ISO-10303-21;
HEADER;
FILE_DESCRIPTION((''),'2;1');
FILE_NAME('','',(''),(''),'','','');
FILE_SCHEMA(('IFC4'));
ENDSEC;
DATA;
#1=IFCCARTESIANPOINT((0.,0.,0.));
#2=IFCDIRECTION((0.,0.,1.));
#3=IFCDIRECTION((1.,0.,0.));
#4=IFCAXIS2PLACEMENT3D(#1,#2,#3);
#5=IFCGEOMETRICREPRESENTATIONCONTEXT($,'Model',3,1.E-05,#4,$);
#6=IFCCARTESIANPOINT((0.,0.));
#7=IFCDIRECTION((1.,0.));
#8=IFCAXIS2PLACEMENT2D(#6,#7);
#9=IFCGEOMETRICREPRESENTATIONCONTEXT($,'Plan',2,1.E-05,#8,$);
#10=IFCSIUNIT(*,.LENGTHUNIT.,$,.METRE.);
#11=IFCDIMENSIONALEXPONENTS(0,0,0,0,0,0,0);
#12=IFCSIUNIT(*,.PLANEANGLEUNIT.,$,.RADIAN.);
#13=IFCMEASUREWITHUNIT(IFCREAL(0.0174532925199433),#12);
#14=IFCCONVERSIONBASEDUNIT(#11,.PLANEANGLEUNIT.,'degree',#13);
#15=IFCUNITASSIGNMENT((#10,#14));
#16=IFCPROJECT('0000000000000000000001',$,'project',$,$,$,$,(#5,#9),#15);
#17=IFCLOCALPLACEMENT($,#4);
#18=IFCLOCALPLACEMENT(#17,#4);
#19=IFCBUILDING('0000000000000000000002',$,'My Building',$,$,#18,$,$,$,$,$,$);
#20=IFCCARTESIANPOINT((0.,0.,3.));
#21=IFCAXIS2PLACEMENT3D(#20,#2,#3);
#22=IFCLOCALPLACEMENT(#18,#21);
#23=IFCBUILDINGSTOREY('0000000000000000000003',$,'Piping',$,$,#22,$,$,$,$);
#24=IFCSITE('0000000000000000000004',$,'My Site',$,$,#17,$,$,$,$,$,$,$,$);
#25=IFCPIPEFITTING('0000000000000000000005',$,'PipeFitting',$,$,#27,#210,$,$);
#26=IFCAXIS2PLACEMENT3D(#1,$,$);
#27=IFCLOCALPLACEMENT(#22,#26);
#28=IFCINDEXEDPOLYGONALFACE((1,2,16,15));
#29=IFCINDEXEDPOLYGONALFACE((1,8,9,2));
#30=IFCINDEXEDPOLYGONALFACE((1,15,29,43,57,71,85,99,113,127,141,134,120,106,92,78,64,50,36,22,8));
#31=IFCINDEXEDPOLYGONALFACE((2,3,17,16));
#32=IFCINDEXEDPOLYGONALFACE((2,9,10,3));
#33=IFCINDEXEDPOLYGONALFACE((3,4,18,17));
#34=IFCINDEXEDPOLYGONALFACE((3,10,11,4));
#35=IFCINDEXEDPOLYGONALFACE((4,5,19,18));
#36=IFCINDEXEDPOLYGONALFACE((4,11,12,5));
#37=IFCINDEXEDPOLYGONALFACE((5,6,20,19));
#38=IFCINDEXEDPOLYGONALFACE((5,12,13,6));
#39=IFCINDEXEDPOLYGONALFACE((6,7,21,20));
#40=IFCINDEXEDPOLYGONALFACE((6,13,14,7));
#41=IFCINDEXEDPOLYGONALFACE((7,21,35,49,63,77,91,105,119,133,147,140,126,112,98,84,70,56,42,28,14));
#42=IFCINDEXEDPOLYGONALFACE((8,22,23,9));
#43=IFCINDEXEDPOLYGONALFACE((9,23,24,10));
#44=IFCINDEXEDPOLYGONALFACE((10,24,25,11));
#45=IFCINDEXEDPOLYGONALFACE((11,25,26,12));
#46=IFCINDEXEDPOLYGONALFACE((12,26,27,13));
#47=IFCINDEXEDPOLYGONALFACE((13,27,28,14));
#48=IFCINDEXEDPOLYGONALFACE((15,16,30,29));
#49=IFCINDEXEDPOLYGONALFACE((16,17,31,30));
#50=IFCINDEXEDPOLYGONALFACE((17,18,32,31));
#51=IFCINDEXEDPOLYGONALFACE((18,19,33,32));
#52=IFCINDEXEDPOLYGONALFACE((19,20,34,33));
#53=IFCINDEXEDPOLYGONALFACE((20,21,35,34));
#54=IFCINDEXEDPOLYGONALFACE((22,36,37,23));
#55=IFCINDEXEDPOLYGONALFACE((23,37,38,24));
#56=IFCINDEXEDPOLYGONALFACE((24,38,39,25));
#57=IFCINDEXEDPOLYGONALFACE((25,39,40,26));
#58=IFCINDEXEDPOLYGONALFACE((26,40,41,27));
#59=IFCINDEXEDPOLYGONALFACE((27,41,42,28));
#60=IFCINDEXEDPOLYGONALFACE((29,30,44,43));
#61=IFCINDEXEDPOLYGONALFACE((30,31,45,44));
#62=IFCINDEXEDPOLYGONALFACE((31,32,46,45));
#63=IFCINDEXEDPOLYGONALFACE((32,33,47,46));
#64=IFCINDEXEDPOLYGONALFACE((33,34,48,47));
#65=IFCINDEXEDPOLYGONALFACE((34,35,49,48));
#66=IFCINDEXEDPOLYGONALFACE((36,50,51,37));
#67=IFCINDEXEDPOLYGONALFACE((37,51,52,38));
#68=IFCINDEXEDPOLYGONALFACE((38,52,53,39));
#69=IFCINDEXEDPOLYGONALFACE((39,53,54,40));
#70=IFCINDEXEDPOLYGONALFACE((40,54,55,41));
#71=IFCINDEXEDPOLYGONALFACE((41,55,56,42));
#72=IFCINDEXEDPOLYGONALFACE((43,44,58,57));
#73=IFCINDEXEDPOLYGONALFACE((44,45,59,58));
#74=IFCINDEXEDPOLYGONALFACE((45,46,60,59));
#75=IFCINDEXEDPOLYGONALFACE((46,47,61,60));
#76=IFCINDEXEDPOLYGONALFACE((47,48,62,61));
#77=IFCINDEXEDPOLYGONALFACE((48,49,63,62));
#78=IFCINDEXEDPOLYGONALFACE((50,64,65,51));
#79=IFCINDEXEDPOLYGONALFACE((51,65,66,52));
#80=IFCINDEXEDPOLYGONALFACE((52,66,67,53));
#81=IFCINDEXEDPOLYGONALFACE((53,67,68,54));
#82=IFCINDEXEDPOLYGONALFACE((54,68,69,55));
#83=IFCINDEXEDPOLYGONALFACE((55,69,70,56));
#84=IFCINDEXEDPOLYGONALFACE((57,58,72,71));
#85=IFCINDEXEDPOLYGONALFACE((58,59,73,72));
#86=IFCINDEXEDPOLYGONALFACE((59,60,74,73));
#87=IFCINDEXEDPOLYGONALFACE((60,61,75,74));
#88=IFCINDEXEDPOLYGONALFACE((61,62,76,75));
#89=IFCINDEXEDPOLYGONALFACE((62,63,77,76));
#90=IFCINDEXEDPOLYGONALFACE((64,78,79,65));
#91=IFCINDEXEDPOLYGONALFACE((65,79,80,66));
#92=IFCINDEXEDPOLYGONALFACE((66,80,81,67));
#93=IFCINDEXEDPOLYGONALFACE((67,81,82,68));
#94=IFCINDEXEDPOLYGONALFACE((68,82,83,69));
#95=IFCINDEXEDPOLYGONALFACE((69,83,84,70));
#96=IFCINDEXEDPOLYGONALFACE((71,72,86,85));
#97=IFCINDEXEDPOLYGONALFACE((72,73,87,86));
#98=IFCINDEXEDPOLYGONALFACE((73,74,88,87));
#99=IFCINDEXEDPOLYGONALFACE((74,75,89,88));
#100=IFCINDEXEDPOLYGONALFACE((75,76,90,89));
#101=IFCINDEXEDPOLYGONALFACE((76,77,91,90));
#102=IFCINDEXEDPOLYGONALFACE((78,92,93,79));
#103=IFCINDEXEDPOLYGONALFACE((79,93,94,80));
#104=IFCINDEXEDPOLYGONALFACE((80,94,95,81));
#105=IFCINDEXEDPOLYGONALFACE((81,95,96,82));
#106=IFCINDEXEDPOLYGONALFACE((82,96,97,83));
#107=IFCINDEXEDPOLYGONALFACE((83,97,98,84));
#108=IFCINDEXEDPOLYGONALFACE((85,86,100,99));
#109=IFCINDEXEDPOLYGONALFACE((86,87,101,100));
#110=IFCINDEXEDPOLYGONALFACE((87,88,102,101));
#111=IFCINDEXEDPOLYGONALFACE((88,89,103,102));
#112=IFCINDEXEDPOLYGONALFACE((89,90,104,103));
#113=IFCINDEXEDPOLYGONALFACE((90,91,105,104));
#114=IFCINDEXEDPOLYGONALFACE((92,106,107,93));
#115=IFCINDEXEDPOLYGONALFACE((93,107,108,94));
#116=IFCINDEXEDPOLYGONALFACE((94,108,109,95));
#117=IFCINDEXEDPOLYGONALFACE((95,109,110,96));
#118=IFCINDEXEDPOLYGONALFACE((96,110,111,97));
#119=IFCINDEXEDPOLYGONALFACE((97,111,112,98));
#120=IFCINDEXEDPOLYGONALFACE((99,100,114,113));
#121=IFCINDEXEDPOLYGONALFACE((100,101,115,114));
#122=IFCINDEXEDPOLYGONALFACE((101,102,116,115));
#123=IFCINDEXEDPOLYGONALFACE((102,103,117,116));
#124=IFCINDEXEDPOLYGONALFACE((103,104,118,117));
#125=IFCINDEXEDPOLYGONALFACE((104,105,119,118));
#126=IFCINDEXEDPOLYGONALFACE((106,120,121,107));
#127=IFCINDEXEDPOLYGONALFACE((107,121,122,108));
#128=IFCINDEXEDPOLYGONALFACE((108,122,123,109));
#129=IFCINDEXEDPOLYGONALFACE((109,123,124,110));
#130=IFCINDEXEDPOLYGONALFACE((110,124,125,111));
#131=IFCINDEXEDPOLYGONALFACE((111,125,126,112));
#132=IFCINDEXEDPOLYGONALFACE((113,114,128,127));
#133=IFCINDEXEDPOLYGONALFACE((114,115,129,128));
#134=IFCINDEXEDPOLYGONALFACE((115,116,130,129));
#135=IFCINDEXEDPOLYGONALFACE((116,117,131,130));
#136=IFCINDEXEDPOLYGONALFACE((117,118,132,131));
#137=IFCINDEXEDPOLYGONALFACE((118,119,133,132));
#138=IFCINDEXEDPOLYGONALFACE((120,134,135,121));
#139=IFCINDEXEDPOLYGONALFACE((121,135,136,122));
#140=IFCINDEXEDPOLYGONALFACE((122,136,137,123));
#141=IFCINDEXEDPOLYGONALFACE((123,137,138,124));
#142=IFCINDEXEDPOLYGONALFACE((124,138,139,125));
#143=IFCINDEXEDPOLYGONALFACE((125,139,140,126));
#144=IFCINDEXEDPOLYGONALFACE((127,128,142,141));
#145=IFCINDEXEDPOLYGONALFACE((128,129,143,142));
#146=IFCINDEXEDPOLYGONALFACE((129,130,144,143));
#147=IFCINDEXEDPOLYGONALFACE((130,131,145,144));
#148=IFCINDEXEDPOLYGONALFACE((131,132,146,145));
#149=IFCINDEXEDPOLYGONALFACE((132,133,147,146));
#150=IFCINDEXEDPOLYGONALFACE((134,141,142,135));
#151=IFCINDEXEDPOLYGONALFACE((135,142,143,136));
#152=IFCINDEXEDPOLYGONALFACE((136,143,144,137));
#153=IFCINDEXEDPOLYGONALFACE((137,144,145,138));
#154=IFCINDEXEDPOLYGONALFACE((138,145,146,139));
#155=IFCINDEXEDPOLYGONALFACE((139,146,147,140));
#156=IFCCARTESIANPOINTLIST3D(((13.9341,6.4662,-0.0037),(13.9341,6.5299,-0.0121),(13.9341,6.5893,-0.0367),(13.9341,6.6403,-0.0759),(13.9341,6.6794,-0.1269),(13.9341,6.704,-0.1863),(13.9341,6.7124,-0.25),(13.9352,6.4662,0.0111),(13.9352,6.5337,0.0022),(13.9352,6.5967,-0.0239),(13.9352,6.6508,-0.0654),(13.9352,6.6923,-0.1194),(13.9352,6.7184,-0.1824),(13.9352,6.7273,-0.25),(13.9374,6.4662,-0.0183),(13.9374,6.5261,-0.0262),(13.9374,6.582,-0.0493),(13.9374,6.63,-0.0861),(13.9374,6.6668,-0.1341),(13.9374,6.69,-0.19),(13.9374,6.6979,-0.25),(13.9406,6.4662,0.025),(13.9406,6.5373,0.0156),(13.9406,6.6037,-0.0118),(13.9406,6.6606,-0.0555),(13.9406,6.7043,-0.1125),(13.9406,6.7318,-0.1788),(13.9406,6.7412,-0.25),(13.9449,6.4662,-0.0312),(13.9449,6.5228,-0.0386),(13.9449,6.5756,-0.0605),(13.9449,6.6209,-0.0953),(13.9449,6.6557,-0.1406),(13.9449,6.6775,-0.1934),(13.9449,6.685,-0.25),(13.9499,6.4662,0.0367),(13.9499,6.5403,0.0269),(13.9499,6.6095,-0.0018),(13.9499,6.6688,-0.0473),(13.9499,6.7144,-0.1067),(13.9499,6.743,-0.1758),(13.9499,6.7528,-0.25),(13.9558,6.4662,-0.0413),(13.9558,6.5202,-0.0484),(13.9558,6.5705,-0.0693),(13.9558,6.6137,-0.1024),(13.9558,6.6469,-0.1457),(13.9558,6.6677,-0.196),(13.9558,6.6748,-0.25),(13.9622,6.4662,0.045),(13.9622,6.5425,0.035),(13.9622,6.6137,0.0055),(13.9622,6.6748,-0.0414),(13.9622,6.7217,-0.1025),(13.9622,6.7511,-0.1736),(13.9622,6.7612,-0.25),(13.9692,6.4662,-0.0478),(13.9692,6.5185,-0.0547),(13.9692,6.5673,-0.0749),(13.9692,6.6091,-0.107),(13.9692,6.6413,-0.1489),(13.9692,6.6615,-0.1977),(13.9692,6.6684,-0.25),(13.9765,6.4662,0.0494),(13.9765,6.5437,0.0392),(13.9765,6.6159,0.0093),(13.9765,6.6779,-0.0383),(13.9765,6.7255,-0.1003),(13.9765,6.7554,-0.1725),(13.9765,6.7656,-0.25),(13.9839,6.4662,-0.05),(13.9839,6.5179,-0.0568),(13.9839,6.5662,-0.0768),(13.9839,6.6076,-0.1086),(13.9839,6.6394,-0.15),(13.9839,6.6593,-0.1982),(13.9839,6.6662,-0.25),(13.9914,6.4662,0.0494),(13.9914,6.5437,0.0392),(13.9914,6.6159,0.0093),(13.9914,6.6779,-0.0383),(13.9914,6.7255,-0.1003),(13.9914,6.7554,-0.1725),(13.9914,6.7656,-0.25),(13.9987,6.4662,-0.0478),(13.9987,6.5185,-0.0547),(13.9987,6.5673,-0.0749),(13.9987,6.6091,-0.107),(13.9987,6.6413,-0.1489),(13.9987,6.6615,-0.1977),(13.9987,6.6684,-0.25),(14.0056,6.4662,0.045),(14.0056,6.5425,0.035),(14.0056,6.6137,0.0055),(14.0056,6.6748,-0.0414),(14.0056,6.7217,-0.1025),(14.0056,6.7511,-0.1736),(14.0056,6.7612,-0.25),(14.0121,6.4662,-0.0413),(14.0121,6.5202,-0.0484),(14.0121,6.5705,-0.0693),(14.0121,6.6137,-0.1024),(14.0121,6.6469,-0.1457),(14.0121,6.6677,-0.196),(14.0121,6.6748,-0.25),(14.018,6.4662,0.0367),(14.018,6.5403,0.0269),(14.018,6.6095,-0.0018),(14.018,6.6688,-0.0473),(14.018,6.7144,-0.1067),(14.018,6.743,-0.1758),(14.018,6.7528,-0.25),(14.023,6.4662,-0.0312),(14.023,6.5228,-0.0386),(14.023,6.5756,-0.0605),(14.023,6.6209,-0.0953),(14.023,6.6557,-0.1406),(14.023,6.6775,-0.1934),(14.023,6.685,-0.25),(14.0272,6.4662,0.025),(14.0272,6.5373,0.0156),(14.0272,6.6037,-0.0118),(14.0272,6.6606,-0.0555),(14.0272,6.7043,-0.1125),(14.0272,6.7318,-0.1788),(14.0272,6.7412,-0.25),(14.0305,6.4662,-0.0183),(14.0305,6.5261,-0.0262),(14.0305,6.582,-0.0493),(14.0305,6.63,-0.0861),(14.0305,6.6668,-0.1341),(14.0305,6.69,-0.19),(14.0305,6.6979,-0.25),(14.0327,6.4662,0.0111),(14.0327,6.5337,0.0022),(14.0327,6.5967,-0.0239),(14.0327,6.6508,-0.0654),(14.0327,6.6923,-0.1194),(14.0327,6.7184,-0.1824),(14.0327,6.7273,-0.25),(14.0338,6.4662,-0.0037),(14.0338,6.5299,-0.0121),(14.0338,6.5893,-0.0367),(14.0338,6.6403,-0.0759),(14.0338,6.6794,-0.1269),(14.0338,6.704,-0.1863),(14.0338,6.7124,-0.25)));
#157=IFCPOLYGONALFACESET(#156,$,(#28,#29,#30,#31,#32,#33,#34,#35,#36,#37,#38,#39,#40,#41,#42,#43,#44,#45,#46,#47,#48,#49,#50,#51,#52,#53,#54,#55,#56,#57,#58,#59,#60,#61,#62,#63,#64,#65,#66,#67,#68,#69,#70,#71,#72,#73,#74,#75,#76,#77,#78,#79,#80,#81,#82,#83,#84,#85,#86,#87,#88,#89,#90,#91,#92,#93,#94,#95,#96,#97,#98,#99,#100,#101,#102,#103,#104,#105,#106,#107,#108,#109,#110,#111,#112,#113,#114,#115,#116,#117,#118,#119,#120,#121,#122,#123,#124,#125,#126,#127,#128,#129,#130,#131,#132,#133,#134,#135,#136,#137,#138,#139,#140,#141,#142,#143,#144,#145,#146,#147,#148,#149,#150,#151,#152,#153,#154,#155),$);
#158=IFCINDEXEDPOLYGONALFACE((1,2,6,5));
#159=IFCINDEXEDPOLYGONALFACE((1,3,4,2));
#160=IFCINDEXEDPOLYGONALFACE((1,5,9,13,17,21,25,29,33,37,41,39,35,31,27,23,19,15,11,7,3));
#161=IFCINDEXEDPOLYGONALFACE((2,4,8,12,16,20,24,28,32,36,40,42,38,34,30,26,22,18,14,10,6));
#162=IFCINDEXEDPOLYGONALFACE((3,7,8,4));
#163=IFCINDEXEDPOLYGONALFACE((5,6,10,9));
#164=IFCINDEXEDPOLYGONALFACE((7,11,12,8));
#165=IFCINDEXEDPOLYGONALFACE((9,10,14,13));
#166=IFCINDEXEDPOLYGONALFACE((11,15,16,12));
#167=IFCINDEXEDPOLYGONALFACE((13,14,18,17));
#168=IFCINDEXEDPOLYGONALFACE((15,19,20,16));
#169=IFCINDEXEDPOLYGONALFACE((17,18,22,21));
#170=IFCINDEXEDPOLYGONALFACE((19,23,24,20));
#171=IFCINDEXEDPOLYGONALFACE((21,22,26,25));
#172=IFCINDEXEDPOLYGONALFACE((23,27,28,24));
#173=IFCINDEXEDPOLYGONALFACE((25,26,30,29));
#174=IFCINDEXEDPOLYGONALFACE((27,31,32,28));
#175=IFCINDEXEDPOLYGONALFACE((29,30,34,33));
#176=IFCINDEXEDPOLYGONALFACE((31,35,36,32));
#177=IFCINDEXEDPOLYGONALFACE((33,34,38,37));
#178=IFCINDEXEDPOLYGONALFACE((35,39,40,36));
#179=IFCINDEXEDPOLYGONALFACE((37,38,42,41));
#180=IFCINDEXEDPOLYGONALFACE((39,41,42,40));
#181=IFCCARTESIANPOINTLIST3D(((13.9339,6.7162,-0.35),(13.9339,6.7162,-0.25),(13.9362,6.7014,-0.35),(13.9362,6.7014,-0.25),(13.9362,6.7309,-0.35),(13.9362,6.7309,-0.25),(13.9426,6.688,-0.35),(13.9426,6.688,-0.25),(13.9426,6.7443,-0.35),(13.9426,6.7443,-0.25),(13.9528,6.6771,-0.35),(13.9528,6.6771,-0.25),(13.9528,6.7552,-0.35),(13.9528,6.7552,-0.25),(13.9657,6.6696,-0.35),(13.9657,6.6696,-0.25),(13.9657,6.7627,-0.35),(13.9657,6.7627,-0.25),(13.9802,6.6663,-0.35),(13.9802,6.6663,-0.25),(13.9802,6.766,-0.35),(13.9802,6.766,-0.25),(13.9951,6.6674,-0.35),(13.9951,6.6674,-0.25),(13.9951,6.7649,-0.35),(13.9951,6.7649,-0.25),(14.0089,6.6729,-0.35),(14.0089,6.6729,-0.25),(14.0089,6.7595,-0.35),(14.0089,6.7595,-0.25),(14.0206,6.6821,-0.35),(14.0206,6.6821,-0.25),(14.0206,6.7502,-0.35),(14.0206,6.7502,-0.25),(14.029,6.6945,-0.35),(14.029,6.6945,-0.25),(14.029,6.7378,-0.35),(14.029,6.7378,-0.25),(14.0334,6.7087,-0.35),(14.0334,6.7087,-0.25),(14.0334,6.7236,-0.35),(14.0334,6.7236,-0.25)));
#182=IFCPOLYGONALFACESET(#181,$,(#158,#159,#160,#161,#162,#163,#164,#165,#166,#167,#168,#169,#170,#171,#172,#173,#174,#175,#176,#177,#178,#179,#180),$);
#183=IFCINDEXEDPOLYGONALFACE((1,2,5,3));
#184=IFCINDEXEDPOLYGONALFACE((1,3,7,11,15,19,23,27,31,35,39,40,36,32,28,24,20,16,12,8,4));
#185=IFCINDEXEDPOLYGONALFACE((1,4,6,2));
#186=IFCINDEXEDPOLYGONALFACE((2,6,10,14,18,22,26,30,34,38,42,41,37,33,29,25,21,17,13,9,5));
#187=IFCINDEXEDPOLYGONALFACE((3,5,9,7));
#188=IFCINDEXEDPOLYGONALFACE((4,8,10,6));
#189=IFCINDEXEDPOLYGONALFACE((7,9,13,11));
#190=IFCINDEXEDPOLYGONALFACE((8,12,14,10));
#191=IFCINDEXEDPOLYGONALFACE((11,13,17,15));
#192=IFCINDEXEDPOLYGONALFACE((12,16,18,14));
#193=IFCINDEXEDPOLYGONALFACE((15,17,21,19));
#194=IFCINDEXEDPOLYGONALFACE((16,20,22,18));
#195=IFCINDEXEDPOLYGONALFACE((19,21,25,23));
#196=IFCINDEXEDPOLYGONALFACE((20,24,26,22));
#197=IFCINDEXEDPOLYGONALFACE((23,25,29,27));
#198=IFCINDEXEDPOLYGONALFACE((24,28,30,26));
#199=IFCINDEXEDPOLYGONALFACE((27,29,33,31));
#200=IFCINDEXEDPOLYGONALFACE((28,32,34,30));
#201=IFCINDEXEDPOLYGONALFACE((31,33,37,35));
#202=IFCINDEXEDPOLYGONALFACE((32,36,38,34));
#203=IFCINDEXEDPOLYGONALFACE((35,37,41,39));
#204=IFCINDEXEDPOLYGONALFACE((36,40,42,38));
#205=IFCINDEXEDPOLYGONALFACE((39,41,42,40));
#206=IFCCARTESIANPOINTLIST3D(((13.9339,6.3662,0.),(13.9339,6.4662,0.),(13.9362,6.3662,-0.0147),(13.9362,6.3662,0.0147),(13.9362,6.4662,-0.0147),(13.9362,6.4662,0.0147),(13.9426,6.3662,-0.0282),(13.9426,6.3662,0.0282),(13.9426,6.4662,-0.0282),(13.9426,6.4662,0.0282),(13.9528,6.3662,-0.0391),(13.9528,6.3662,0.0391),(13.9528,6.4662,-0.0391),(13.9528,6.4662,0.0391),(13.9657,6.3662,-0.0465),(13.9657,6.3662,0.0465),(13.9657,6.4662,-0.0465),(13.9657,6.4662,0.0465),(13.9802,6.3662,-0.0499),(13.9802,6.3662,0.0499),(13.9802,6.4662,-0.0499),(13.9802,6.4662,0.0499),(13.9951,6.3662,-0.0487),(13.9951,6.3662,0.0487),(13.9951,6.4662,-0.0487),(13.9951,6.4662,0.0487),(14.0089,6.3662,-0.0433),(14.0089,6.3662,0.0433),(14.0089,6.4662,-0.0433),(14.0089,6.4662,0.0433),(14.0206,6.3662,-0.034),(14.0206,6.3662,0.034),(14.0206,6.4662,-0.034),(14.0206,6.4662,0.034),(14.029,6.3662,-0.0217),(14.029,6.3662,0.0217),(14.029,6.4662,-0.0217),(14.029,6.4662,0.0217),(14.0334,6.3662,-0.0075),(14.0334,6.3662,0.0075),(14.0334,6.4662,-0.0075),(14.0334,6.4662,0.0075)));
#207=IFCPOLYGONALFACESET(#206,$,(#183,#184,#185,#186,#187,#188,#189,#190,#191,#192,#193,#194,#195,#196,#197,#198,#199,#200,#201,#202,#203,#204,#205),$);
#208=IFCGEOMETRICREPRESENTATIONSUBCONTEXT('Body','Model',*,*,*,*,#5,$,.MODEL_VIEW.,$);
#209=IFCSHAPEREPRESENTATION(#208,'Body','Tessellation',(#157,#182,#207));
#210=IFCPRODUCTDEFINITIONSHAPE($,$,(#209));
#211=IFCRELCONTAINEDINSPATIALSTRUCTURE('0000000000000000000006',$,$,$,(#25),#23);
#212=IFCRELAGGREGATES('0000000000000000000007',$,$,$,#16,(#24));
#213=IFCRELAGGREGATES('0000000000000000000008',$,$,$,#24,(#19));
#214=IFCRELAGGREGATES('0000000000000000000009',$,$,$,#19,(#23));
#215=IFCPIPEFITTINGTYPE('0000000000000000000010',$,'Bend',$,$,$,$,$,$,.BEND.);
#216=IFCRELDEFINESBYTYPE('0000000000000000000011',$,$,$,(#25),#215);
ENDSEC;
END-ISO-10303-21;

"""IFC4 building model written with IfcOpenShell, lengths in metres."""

from ifc_helpers import new_model, entity, si_unit, converted_unit, frame, origin_with_axes, origin_2d_with_axis, place, context, subcontext, project, spatial, circle, extrude, source, transform, mapped, type_object, type_shapes, element, save


model = new_model("IFC4")

# Units and contexts
model_context = context("Model", 3, precision=1e-05, world=origin_with_axes())
plan_context = context("Plan", 2, precision=1e-05, world=origin_2d_with_axis())
body_context = subcontext(model_context, "Body", "Model", "MODEL_VIEW")
ifc_project = project(units=[si_unit("LENGTHUNIT", "METRE"), converted_unit("PLANEANGLEUNIT", "degree", entity("IfcReal", 0.0174532925199433), si_unit("PLANEANGLEUNIT", "RADIAN"), dimensions=[0, 0, 0, 0, 0, 0, 0])], contexts=[model_context, plan_context])

# Site, building, storey
site_placement = place(None, origin_with_axes())
site = spatial("IfcSite", under=ifc_project, at=site_placement, Name="My Site")
building_placement = place(site_placement, origin_with_axes())
building = spatial("IfcBuilding", under=site, at=building_placement, Name="My Building")
storey_placement = place(building_placement, frame((0.0, 0.0, 3.0), z_axis=(0.0, 0.0, 1.0), x_axis=(1.0, 0.0, 0.0)))
storey = spatial("IfcBuildingStorey", under=building, at=storey_placement, Name="Piping")

# Pipe fitting
pipe_fitting_type = type_object("IfcPipeFittingType", Name="Bend", PredefinedType="BEND")
shared_shape = source(origin_with_axes(), body_context, "Body", "SolidModel", [
    entity("IfcSweptDiskSolid", entity("IfcIndexedPolyCurve", entity("IfcCartesianPointList3D", [[0.0, 0.0, -0.1], [0.0, -0.0732, -0.2768], [0.0, -0.25, -0.35]]), [entity("IfcArcIndex", [1, 2, 3])]), 0.05),
    extrude(circle(Radius=0.05), origin_with_axes(), (0.0, 0.0, -1.0), 0.1),
    extrude(circle(Radius=0.05), frame((0.0, -0.25, -0.35), z_axis=(0.0, -1.0, 0.0), x_axis=(1.0, 0.0, 0.0)), (0.0, 0.0, 1.0), 0.1),
])
type_shapes(pipe_fitting_type, [shared_shape])
for number, where, z_axis, x_axis, name in (
    (1, (13.9839, 6.7162, -0.35), (0.0, 0.0, -1.0), (-1.0, 0.0, 0.0), "PipeFitting"),
):
    element("IfcPipeFitting", number, at=place(storey_placement, frame(where, z_axis=z_axis, x_axis=x_axis)), inside=storey, type_object=pipe_fitting_type, Name=name, context=body_context, shape_type="MappedRepresentation", body=[
        mapped(shared_shape, transform((0.0, 0.0, 0.0), x_axis=(1.0, 0.0, 0.0), y_axis=(0.0, 1.0, 0.0), z_axis=(0.0, 0.0, 1.0), scale=1.0)),
    ])

save(model, "model.ifc")
